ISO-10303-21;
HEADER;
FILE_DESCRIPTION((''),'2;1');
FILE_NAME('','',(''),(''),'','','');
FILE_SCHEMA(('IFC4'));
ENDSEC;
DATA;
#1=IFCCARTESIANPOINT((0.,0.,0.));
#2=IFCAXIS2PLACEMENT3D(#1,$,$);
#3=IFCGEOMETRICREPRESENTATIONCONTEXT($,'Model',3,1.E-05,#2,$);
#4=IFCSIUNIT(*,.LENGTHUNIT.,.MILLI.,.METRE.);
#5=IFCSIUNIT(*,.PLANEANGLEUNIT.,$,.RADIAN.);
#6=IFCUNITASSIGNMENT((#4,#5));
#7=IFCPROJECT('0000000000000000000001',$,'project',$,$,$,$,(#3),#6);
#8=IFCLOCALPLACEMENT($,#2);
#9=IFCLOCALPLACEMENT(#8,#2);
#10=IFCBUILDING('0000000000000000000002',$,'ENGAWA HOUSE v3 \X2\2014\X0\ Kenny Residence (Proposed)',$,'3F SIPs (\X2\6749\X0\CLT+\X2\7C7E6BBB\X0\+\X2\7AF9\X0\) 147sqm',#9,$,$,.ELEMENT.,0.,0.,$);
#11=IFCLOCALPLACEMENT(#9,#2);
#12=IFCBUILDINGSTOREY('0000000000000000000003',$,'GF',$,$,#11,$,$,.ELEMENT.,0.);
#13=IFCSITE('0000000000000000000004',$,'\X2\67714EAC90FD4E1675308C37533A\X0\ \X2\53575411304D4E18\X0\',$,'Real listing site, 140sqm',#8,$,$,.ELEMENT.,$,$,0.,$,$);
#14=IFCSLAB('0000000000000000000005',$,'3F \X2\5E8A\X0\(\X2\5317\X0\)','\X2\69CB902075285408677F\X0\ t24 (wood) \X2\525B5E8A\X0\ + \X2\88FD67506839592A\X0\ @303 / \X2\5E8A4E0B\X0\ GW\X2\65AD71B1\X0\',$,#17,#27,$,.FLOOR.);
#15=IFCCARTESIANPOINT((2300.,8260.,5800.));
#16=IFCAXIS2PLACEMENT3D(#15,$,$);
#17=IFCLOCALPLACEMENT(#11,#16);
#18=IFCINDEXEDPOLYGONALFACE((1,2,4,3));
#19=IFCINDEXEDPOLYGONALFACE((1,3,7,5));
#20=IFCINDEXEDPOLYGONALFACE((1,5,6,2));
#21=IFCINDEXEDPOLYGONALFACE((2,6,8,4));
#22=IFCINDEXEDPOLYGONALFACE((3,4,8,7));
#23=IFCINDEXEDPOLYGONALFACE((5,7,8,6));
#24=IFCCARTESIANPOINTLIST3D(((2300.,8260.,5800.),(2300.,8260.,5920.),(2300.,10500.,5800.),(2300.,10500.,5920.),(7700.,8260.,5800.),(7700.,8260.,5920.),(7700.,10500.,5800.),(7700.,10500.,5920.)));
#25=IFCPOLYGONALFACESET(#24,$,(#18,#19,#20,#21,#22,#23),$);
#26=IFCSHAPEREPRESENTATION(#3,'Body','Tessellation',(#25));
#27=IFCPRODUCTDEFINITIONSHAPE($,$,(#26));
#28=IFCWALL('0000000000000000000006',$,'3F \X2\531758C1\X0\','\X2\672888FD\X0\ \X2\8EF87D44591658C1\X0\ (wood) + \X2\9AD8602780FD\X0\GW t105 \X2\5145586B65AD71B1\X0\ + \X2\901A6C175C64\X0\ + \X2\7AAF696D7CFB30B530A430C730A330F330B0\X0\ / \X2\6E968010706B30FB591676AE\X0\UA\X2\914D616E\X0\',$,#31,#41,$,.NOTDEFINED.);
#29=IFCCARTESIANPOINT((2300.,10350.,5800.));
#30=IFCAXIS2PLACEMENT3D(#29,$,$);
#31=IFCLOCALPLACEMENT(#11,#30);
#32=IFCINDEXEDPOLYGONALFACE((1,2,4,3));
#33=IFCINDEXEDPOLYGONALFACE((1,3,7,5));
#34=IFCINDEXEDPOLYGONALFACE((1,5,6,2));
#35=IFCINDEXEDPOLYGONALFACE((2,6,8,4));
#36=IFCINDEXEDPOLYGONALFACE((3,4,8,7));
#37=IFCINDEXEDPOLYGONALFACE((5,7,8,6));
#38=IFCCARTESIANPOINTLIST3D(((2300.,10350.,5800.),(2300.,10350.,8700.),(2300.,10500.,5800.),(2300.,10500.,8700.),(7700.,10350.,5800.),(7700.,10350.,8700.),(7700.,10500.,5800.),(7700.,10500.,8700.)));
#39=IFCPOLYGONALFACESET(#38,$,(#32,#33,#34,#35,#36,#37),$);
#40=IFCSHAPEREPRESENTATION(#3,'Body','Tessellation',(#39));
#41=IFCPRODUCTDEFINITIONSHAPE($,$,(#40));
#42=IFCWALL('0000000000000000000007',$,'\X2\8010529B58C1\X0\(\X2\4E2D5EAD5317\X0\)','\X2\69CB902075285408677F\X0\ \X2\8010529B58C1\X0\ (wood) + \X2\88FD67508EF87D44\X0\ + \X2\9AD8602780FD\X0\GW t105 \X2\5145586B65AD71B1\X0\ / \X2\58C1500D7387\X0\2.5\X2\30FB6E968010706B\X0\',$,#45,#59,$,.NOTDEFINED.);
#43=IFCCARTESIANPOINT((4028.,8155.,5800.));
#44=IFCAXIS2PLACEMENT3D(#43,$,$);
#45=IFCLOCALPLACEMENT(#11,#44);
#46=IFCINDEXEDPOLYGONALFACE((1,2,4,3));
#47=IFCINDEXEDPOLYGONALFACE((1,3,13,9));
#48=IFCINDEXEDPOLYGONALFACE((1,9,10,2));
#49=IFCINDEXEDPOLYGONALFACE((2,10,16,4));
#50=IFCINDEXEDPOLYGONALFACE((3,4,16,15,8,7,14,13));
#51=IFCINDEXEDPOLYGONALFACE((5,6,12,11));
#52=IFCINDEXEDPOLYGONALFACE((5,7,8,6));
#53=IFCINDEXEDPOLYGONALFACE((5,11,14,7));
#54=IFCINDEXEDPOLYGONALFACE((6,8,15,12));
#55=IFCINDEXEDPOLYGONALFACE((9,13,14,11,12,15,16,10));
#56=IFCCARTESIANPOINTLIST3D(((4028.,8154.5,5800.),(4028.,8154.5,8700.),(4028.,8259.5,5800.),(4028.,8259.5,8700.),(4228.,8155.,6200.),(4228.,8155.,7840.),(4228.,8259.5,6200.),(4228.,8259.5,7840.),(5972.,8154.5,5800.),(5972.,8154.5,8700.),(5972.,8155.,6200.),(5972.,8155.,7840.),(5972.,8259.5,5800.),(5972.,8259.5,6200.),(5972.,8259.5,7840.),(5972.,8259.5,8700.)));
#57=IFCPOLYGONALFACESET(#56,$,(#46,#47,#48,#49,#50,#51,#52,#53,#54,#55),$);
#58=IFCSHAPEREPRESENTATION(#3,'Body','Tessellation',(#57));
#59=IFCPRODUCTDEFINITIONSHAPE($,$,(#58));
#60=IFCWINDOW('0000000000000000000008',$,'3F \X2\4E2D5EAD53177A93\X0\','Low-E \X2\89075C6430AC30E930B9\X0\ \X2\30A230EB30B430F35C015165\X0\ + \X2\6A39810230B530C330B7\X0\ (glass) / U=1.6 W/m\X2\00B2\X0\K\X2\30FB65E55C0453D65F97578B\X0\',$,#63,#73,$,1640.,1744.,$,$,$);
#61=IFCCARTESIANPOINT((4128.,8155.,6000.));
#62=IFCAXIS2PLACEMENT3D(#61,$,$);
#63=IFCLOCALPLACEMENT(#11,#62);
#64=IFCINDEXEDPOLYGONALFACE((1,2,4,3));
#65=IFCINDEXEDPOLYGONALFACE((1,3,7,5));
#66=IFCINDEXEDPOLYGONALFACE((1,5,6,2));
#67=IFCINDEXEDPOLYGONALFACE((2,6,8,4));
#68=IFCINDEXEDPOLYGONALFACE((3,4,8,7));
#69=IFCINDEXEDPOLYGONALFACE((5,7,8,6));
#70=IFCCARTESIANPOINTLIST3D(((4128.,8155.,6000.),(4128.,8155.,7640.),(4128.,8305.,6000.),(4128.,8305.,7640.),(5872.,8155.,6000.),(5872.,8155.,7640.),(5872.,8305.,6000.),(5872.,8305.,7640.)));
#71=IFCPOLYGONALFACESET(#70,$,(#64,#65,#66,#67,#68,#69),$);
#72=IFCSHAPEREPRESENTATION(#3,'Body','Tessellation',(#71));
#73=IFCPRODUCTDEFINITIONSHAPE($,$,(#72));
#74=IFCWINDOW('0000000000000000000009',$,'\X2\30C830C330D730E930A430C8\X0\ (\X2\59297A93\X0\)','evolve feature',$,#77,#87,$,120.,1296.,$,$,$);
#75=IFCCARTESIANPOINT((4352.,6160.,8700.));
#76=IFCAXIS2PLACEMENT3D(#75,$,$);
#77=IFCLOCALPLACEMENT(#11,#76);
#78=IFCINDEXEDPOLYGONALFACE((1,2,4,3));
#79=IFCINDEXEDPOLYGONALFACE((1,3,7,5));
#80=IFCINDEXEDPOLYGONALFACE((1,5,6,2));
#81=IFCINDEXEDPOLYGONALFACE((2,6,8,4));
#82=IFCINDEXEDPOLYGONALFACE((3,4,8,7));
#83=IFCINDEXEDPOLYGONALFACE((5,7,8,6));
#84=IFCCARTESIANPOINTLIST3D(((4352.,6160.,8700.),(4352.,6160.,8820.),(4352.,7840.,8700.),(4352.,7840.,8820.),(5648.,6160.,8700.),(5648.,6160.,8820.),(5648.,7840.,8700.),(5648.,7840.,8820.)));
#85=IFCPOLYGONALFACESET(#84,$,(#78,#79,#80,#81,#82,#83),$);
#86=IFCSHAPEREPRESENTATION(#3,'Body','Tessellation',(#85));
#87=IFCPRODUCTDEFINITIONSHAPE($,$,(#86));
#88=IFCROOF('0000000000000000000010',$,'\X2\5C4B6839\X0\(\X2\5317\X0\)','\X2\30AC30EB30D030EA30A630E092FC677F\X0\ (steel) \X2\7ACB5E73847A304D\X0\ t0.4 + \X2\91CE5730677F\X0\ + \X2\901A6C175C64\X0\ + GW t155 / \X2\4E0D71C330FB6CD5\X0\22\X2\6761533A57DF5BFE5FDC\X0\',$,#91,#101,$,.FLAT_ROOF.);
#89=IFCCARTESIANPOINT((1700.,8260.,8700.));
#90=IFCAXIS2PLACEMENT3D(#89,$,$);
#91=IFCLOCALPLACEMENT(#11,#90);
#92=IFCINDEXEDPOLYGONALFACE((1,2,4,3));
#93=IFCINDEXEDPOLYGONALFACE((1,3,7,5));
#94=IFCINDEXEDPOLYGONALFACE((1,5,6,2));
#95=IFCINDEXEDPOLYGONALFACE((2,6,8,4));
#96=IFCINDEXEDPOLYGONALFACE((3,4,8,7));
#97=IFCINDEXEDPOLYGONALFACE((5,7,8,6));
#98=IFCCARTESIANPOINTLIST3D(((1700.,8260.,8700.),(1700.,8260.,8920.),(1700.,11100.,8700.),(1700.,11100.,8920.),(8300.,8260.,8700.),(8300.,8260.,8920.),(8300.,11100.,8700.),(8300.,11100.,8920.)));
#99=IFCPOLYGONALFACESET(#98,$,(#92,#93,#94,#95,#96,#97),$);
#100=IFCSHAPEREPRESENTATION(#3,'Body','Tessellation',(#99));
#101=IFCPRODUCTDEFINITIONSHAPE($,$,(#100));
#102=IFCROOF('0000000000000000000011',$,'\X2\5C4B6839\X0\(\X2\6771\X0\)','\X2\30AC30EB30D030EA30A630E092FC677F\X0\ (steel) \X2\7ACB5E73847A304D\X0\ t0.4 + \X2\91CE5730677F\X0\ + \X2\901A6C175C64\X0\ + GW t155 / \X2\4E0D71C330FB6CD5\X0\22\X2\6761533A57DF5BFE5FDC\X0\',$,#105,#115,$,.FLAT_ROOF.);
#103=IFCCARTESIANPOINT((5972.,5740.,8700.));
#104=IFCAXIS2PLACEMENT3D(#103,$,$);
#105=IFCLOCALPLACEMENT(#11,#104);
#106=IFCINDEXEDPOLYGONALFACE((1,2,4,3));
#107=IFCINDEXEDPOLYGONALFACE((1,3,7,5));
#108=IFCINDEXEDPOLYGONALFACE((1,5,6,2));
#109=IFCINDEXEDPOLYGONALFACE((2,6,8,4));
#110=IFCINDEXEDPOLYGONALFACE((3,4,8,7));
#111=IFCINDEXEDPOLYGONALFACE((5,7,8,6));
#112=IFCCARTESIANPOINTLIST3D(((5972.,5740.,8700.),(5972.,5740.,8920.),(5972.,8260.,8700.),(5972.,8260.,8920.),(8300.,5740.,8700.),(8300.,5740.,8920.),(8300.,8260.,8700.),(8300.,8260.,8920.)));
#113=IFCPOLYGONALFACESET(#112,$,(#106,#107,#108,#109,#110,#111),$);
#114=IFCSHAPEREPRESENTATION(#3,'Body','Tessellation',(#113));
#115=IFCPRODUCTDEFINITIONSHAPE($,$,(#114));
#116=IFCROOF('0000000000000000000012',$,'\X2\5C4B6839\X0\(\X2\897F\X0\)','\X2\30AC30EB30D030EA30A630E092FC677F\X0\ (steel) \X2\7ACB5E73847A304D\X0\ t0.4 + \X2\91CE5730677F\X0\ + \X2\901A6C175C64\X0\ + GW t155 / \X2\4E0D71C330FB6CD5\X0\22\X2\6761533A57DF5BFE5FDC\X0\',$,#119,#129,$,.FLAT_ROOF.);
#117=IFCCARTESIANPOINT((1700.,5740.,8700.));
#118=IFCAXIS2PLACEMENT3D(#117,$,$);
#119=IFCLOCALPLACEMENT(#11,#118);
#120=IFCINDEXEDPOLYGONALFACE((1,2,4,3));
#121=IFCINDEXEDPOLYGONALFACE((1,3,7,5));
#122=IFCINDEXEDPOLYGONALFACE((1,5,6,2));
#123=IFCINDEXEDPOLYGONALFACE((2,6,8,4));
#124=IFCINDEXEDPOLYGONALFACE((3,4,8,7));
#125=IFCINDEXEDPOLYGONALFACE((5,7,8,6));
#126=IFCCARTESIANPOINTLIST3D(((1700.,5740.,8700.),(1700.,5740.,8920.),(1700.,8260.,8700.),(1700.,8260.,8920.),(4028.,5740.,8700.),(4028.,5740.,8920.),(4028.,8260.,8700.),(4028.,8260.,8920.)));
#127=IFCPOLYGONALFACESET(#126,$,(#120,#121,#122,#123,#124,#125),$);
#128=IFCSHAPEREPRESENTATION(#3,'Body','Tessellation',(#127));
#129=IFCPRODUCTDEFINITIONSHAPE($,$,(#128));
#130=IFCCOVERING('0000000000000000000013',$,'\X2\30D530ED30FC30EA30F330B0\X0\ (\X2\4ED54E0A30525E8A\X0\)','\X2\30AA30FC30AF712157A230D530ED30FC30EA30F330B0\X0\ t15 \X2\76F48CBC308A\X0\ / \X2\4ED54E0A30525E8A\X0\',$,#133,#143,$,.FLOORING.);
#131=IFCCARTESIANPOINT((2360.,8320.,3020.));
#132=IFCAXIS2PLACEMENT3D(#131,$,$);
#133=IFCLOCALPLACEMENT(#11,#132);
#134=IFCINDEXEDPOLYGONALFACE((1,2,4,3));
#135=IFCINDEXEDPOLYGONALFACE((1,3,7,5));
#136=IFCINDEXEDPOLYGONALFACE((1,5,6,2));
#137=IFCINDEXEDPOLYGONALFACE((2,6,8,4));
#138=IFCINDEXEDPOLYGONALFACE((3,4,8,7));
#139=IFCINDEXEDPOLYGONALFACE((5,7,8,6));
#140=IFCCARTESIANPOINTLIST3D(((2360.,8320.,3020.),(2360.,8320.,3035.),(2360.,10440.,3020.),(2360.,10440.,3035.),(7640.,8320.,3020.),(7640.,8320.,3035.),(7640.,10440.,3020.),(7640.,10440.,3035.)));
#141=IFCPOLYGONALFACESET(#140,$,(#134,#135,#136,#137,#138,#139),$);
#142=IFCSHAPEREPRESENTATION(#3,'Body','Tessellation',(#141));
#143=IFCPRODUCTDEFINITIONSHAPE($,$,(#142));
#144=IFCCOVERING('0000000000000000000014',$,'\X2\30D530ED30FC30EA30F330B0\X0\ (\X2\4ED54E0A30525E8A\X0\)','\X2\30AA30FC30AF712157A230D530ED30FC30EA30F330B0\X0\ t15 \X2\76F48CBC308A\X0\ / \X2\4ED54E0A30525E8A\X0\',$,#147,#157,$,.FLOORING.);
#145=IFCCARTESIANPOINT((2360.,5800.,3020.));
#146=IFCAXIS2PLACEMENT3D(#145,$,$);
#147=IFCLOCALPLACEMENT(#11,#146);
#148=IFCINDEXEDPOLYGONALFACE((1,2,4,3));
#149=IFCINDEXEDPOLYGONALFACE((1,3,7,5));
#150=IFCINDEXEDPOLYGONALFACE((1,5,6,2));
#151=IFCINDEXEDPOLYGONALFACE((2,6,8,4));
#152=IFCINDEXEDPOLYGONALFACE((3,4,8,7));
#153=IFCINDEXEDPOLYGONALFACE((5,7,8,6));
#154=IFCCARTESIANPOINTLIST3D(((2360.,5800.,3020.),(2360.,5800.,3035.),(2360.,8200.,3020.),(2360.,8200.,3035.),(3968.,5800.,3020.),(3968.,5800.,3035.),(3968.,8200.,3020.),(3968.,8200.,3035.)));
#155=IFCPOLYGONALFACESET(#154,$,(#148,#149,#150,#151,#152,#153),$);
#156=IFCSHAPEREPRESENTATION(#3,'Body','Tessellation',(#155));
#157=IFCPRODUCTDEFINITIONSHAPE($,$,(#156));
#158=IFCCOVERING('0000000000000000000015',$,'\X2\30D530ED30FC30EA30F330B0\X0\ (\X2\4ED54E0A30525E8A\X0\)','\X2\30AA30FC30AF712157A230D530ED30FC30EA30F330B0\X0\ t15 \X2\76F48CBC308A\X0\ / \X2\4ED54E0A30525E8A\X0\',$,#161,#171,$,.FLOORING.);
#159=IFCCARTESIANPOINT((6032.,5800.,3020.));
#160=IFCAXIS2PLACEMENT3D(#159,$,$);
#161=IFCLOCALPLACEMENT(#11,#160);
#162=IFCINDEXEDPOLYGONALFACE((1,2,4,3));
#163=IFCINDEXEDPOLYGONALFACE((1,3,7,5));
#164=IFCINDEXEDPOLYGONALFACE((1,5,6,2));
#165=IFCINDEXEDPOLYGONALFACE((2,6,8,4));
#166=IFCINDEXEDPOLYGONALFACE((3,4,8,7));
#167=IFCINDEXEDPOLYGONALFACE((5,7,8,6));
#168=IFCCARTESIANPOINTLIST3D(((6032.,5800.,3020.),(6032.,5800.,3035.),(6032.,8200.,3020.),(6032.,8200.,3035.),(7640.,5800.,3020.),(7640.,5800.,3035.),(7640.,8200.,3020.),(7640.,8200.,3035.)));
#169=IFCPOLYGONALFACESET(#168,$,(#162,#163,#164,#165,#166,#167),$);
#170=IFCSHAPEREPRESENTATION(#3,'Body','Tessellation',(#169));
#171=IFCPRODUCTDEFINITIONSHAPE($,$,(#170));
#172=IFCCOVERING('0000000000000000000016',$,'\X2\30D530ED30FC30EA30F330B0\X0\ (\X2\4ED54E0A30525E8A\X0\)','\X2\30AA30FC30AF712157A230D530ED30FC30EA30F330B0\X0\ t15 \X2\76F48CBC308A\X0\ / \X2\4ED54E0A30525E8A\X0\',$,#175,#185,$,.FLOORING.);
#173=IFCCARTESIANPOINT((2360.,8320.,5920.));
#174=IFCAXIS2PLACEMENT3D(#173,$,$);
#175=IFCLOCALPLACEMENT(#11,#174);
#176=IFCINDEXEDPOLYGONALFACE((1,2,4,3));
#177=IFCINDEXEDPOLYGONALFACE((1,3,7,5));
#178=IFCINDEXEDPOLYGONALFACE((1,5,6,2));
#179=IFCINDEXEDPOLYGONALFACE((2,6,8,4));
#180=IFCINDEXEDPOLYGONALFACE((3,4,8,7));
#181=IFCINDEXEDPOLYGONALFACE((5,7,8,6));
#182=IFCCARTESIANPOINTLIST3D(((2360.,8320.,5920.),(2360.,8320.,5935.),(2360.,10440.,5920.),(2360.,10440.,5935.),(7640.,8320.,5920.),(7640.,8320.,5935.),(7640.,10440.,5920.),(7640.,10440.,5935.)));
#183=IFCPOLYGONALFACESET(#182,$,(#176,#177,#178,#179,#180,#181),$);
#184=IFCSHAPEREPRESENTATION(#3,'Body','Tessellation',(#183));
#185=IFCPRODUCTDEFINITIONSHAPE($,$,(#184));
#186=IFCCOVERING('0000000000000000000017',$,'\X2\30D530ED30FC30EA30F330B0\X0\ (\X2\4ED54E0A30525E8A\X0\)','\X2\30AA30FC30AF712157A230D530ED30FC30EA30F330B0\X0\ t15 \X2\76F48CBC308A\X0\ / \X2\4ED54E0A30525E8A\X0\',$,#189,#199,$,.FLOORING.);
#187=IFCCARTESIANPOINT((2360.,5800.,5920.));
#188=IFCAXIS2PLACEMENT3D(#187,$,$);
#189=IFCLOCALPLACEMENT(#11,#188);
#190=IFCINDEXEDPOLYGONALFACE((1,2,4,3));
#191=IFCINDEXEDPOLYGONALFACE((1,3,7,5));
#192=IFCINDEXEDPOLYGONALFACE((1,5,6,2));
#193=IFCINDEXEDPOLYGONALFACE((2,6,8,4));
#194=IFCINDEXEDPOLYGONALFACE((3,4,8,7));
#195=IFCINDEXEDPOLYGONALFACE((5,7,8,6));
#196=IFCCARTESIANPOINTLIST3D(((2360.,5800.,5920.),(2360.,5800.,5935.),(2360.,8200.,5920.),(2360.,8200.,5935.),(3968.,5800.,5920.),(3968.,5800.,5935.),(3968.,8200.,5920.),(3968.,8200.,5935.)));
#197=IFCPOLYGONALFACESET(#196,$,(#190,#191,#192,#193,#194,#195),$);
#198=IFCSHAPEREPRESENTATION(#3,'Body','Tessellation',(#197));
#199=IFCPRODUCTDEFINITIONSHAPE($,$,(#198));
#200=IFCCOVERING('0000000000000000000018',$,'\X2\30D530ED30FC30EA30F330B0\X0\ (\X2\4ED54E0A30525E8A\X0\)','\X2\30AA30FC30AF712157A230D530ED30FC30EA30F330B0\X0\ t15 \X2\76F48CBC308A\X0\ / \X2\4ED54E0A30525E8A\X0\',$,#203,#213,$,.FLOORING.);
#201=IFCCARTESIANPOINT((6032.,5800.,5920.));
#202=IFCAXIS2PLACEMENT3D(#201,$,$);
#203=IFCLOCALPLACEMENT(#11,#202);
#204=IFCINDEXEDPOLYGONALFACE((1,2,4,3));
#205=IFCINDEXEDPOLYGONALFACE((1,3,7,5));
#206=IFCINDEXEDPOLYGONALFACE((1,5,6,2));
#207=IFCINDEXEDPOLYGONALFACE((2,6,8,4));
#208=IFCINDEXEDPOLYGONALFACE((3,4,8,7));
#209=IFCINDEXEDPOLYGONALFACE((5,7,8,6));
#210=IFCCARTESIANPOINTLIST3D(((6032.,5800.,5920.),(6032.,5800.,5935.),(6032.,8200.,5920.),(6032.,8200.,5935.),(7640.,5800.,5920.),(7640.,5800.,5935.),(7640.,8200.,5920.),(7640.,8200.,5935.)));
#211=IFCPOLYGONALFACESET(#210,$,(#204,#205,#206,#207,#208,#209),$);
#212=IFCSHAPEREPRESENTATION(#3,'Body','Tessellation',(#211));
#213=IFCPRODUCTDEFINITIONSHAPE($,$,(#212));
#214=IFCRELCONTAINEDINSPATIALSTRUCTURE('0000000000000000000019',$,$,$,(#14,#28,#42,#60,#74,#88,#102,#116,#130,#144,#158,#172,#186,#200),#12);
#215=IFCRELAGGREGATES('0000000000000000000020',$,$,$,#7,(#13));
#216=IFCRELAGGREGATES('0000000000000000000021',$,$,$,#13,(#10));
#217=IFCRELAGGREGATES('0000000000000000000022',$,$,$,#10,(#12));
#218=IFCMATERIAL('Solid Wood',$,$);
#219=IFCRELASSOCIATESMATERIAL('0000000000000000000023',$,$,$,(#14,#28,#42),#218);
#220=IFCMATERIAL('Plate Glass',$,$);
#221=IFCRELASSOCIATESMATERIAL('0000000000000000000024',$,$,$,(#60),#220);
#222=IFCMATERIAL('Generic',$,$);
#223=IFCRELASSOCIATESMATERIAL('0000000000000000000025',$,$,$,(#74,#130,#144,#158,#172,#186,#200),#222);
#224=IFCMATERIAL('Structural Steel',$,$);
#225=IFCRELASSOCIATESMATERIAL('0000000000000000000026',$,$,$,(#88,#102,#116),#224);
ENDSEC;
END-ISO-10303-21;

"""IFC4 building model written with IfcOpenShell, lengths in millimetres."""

from ifc_helpers import new_model, si_unit, frame, frame_2d, origin, place, context, project, spatial, rectangle, extrude, material, element, fill, save


model = new_model("IFC4")

# Units and contexts
model_context = context("Model", 3, precision=1e-05, world=origin())
ifc_project = project(units=[si_unit("LENGTHUNIT", "METRE", prefix="MILLI"), si_unit("PLANEANGLEUNIT", "RADIAN")], contexts=[model_context])

# Site, building, storey
site_placement = place(None, origin())
site = spatial("IfcSite", under=ifc_project, at=site_placement, Name="東京都世田谷区 南向き丘", ObjectType="Real listing site, 140sqm", CompositionType="ELEMENT", RefElevation=0.0)
building_placement = place(site_placement, origin())
building = spatial("IfcBuilding", under=site, at=building_placement, Name="ENGAWA HOUSE v3 — Kenny Residence (Proposed)", ObjectType="3F SIPs (杉CLT+籾殻+竹) 147sqm", CompositionType="ELEMENT", ElevationOfRefHeight=0.0, ElevationOfTerrain=0.0)
storey_placement = place(building_placement, origin())
storey = spatial("IfcBuildingStorey", under=building, at=storey_placement, Name="GF", CompositionType="ELEMENT", Elevation=0.0)

# Slab
ifc_material_1 = material(Name="Solid Wood")
slab_placement = place(storey_placement, frame((2300.0, 8260.0, 5800.0)))
element("IfcSlab", 1, at=slab_placement, inside=storey, material=ifc_material_1, Name="3F 床(北)", Description="構造用合板 t24 (wood) 剛床 + 製材根太 @303 / 床下 GW断熱", PredefinedType="FLOOR", context=model_context, shape_type="SweptSolid", body=[
    extrude(rectangle(XDim=5400.0, YDim=2240.0, at=frame_2d((2700.0, 1120.0))), frame((2300.0, 8260.0, 5800.0)), (0.0, 0.0, 1.0), 120.0),
])

# Wall
wall_1_placement = place(storey_placement, frame((2300.0, 10350.0, 5800.0)))
element("IfcWall", 2, at=wall_1_placement, inside=storey, material=ifc_material_1, Name="3F 北壁", Description="木製 軸組外壁 (wood) + 高性能GW t105 充填断熱 + 通気層 + 窯業系サイディング / 準耐火・外皮UA配慮", PredefinedType="NOTDEFINED", context=model_context, shape_type="SweptSolid", body=[
    extrude(rectangle(XDim=5400.0, YDim=150.0, at=frame_2d((2700.0, 75.0))), frame((2300.0, 10350.0, 5800.0)), (0.0, 0.0, 1.0), 2900.0),
])

# Wall, opening, window
wall_2_placement = place(storey_placement, frame((4028.0, 8155.0, 5800.0)))
wall_2 = element("IfcWall", 3, at=wall_2_placement, inside=storey, material=ifc_material_1, Name="耐力壁(中庭北)", Description="構造用合板 耐力壁 (wood) + 製材軸組 + 高性能GW t105 充填断熱 / 壁倍率2.5・準耐火", PredefinedType="NOTDEFINED", context=model_context, shape_type="SweptSolid", body=[
    extrude(rectangle(XDim=1944.0, YDim=105.0, at=frame_2d((972.0, 52.0))), frame((4028.0, 8155.0, 5800.0)), (0.0, 0.0, 1.0), 2900.0),
])
opening_placement = place(storey_placement, frame((4128.0, 8155.0, 6000.0)))
opening = element("IfcOpeningElement", 4, at=opening_placement, cuts=wall_2, PredefinedType="NOTDEFINED", context=model_context, shape_type="SweptSolid", body=[
    extrude(rectangle(XDim=1744.0, YDim=150.0, at=frame_2d((872.0, 75.0))), frame((4128.0, 8155.0, 6000.0)), (0.0, 0.0, 1.0), 1640.0),
])
ifc_material_2 = material(Name="Plate Glass")
window_1_placement = place(storey_placement, frame((4128.0, 8155.0, 6000.0)))
window_1 = element("IfcWindow", 5, at=window_1_placement, inside=storey, material=ifc_material_2, Name="3F 中庭北窓", Description="Low-E 複層ガラス アルゴン封入 + 樹脂サッシ (glass) / U=1.6 W/m²K・日射取得型", OverallHeight=1640.0, OverallWidth=1744.0, context=model_context, shape_type="SweptSolid", body=[
    extrude(rectangle(XDim=1744.0, YDim=150.0, at=frame_2d((872.0, 75.0))), frame((4128.0, 8155.0, 6000.0)), (0.0, 0.0, 1.0), 1640.0),
])
fill(opening, window_1)

# Window
ifc_material_3 = material(Name="Generic")
window_2_placement = place(storey_placement, frame((4352.0, 6160.0, 8700.0)))
element("IfcWindow", 6, at=window_2_placement, inside=storey, material=ifc_material_3, Name="トップライト (天窓)", Description="evolve feature", OverallHeight=120.0, OverallWidth=1296.0, context=model_context, shape_type="SweptSolid", body=[
    extrude(rectangle(XDim=1296.0, YDim=1680.0, at=frame_2d((648.0, 840.0))), frame((4352.0, 6160.0, 8700.0)), (0.0, 0.0, 1.0), 120.0),
])

# Roofs
ifc_material_4 = material(Name="Structural Steel")
roof_1_placement = place(storey_placement, frame((1700.0, 8260.0, 8700.0)))
element("IfcRoof", 7, at=roof_1_placement, inside=storey, material=ifc_material_4, Name="屋根(北)", Description="ガルバリウム鋼板 (steel) 立平葺き t0.4 + 野地板 + 通気層 + GW t155 / 不燃・法22条区域対応", PredefinedType="FLAT_ROOF", context=model_context, shape_type="SweptSolid", body=[
    extrude(rectangle(XDim=6600.0, YDim=2840.0, at=frame_2d((3300.0, 1420.0))), frame((1700.0, 8260.0, 8700.0)), (0.0, 0.0, 1.0), 220.0),
])
roof_2_placement = place(storey_placement, frame((5972.0, 5740.0, 8700.0)))
element("IfcRoof", 8, at=roof_2_placement, inside=storey, material=ifc_material_4, Name="屋根(東)", Description="ガルバリウム鋼板 (steel) 立平葺き t0.4 + 野地板 + 通気層 + GW t155 / 不燃・法22条区域対応", PredefinedType="FLAT_ROOF", context=model_context, shape_type="SweptSolid", body=[
    extrude(rectangle(XDim=2328.0, YDim=2520.0, at=frame_2d((1164.0, 1260.0))), frame((5972.0, 5740.0, 8700.0)), (0.0, 0.0, 1.0), 220.0),
])
roof_3_placement = place(storey_placement, frame((1700.0, 5740.0, 8700.0)))
element("IfcRoof", 9, at=roof_3_placement, inside=storey, material=ifc_material_4, Name="屋根(西)", Description="ガルバリウム鋼板 (steel) 立平葺き t0.4 + 野地板 + 通気層 + GW t155 / 不燃・法22条区域対応", PredefinedType="FLAT_ROOF", context=model_context, shape_type="SweptSolid", body=[
    extrude(rectangle(XDim=2328.0, YDim=2520.0, at=frame_2d((1164.0, 1260.0))), frame((1700.0, 5740.0, 8700.0)), (0.0, 0.0, 1.0), 220.0),
])

# Coverings
covering_1_placement = place(storey_placement, frame((2360.0, 8320.0, 3020.0)))
element("IfcCovering", 10, at=covering_1_placement, inside=storey, material=ifc_material_3, Name="フローリング (仕上げ床)", Description="オーク無垢フローリング t15 直貼り / 仕上げ床", PredefinedType="FLOORING", context=model_context, shape_type="SweptSolid", body=[
    extrude(rectangle(XDim=5280.0, YDim=2120.0, at=frame_2d((2640.0, 1060.0))), frame((2360.0, 8320.0, 3020.0)), (0.0, 0.0, 1.0), 15.0),
])
covering_2_placement = place(storey_placement, frame((2360.0, 5800.0, 3020.0)))
element("IfcCovering", 11, at=covering_2_placement, inside=storey, material=ifc_material_3, Name="フローリング (仕上げ床)", Description="オーク無垢フローリング t15 直貼り / 仕上げ床", PredefinedType="FLOORING", context=model_context, shape_type="SweptSolid", body=[
    extrude(rectangle(XDim=1608.0, YDim=2400.0, at=frame_2d((804.0, 1200.0))), frame((2360.0, 5800.0, 3020.0)), (0.0, 0.0, 1.0), 15.0),
])
covering_3_placement = place(storey_placement, frame((6032.0, 5800.0, 3020.0)))
element("IfcCovering", 12, at=covering_3_placement, inside=storey, material=ifc_material_3, Name="フローリング (仕上げ床)", Description="オーク無垢フローリング t15 直貼り / 仕上げ床", PredefinedType="FLOORING", context=model_context, shape_type="SweptSolid", body=[
    extrude(rectangle(XDim=1608.0, YDim=2400.0, at=frame_2d((804.0, 1200.0))), frame((6032.0, 5800.0, 3020.0)), (0.0, 0.0, 1.0), 15.0),
])
covering_4_placement = place(storey_placement, frame((2360.0, 8320.0, 5920.0)))
element("IfcCovering", 13, at=covering_4_placement, inside=storey, material=ifc_material_3, Name="フローリング (仕上げ床)", Description="オーク無垢フローリング t15 直貼り / 仕上げ床", PredefinedType="FLOORING", context=model_context, shape_type="SweptSolid", body=[
    extrude(rectangle(XDim=5280.0, YDim=2120.0, at=frame_2d((2640.0, 1060.0))), frame((2360.0, 8320.0, 5920.0)), (0.0, 0.0, 1.0), 15.0),
])
covering_5_placement = place(storey_placement, frame((2360.0, 5800.0, 5920.0)))
element("IfcCovering", 14, at=covering_5_placement, inside=storey, material=ifc_material_3, Name="フローリング (仕上げ床)", Description="オーク無垢フローリング t15 直貼り / 仕上げ床", PredefinedType="FLOORING", context=model_context, shape_type="SweptSolid", body=[
    extrude(rectangle(XDim=1608.0, YDim=2400.0, at=frame_2d((804.0, 1200.0))), frame((2360.0, 5800.0, 5920.0)), (0.0, 0.0, 1.0), 15.0),
])
covering_6_placement = place(storey_placement, frame((6032.0, 5800.0, 5920.0)))
element("IfcCovering", 15, at=covering_6_placement, inside=storey, material=ifc_material_3, Name="フローリング (仕上げ床)", Description="オーク無垢フローリング t15 直貼り / 仕上げ床", PredefinedType="FLOORING", context=model_context, shape_type="SweptSolid", body=[
    extrude(rectangle(XDim=1608.0, YDim=2400.0, at=frame_2d((804.0, 1200.0))), frame((6032.0, 5800.0, 5920.0)), (0.0, 0.0, 1.0), 15.0),
])

save(model, "model.ifc")
